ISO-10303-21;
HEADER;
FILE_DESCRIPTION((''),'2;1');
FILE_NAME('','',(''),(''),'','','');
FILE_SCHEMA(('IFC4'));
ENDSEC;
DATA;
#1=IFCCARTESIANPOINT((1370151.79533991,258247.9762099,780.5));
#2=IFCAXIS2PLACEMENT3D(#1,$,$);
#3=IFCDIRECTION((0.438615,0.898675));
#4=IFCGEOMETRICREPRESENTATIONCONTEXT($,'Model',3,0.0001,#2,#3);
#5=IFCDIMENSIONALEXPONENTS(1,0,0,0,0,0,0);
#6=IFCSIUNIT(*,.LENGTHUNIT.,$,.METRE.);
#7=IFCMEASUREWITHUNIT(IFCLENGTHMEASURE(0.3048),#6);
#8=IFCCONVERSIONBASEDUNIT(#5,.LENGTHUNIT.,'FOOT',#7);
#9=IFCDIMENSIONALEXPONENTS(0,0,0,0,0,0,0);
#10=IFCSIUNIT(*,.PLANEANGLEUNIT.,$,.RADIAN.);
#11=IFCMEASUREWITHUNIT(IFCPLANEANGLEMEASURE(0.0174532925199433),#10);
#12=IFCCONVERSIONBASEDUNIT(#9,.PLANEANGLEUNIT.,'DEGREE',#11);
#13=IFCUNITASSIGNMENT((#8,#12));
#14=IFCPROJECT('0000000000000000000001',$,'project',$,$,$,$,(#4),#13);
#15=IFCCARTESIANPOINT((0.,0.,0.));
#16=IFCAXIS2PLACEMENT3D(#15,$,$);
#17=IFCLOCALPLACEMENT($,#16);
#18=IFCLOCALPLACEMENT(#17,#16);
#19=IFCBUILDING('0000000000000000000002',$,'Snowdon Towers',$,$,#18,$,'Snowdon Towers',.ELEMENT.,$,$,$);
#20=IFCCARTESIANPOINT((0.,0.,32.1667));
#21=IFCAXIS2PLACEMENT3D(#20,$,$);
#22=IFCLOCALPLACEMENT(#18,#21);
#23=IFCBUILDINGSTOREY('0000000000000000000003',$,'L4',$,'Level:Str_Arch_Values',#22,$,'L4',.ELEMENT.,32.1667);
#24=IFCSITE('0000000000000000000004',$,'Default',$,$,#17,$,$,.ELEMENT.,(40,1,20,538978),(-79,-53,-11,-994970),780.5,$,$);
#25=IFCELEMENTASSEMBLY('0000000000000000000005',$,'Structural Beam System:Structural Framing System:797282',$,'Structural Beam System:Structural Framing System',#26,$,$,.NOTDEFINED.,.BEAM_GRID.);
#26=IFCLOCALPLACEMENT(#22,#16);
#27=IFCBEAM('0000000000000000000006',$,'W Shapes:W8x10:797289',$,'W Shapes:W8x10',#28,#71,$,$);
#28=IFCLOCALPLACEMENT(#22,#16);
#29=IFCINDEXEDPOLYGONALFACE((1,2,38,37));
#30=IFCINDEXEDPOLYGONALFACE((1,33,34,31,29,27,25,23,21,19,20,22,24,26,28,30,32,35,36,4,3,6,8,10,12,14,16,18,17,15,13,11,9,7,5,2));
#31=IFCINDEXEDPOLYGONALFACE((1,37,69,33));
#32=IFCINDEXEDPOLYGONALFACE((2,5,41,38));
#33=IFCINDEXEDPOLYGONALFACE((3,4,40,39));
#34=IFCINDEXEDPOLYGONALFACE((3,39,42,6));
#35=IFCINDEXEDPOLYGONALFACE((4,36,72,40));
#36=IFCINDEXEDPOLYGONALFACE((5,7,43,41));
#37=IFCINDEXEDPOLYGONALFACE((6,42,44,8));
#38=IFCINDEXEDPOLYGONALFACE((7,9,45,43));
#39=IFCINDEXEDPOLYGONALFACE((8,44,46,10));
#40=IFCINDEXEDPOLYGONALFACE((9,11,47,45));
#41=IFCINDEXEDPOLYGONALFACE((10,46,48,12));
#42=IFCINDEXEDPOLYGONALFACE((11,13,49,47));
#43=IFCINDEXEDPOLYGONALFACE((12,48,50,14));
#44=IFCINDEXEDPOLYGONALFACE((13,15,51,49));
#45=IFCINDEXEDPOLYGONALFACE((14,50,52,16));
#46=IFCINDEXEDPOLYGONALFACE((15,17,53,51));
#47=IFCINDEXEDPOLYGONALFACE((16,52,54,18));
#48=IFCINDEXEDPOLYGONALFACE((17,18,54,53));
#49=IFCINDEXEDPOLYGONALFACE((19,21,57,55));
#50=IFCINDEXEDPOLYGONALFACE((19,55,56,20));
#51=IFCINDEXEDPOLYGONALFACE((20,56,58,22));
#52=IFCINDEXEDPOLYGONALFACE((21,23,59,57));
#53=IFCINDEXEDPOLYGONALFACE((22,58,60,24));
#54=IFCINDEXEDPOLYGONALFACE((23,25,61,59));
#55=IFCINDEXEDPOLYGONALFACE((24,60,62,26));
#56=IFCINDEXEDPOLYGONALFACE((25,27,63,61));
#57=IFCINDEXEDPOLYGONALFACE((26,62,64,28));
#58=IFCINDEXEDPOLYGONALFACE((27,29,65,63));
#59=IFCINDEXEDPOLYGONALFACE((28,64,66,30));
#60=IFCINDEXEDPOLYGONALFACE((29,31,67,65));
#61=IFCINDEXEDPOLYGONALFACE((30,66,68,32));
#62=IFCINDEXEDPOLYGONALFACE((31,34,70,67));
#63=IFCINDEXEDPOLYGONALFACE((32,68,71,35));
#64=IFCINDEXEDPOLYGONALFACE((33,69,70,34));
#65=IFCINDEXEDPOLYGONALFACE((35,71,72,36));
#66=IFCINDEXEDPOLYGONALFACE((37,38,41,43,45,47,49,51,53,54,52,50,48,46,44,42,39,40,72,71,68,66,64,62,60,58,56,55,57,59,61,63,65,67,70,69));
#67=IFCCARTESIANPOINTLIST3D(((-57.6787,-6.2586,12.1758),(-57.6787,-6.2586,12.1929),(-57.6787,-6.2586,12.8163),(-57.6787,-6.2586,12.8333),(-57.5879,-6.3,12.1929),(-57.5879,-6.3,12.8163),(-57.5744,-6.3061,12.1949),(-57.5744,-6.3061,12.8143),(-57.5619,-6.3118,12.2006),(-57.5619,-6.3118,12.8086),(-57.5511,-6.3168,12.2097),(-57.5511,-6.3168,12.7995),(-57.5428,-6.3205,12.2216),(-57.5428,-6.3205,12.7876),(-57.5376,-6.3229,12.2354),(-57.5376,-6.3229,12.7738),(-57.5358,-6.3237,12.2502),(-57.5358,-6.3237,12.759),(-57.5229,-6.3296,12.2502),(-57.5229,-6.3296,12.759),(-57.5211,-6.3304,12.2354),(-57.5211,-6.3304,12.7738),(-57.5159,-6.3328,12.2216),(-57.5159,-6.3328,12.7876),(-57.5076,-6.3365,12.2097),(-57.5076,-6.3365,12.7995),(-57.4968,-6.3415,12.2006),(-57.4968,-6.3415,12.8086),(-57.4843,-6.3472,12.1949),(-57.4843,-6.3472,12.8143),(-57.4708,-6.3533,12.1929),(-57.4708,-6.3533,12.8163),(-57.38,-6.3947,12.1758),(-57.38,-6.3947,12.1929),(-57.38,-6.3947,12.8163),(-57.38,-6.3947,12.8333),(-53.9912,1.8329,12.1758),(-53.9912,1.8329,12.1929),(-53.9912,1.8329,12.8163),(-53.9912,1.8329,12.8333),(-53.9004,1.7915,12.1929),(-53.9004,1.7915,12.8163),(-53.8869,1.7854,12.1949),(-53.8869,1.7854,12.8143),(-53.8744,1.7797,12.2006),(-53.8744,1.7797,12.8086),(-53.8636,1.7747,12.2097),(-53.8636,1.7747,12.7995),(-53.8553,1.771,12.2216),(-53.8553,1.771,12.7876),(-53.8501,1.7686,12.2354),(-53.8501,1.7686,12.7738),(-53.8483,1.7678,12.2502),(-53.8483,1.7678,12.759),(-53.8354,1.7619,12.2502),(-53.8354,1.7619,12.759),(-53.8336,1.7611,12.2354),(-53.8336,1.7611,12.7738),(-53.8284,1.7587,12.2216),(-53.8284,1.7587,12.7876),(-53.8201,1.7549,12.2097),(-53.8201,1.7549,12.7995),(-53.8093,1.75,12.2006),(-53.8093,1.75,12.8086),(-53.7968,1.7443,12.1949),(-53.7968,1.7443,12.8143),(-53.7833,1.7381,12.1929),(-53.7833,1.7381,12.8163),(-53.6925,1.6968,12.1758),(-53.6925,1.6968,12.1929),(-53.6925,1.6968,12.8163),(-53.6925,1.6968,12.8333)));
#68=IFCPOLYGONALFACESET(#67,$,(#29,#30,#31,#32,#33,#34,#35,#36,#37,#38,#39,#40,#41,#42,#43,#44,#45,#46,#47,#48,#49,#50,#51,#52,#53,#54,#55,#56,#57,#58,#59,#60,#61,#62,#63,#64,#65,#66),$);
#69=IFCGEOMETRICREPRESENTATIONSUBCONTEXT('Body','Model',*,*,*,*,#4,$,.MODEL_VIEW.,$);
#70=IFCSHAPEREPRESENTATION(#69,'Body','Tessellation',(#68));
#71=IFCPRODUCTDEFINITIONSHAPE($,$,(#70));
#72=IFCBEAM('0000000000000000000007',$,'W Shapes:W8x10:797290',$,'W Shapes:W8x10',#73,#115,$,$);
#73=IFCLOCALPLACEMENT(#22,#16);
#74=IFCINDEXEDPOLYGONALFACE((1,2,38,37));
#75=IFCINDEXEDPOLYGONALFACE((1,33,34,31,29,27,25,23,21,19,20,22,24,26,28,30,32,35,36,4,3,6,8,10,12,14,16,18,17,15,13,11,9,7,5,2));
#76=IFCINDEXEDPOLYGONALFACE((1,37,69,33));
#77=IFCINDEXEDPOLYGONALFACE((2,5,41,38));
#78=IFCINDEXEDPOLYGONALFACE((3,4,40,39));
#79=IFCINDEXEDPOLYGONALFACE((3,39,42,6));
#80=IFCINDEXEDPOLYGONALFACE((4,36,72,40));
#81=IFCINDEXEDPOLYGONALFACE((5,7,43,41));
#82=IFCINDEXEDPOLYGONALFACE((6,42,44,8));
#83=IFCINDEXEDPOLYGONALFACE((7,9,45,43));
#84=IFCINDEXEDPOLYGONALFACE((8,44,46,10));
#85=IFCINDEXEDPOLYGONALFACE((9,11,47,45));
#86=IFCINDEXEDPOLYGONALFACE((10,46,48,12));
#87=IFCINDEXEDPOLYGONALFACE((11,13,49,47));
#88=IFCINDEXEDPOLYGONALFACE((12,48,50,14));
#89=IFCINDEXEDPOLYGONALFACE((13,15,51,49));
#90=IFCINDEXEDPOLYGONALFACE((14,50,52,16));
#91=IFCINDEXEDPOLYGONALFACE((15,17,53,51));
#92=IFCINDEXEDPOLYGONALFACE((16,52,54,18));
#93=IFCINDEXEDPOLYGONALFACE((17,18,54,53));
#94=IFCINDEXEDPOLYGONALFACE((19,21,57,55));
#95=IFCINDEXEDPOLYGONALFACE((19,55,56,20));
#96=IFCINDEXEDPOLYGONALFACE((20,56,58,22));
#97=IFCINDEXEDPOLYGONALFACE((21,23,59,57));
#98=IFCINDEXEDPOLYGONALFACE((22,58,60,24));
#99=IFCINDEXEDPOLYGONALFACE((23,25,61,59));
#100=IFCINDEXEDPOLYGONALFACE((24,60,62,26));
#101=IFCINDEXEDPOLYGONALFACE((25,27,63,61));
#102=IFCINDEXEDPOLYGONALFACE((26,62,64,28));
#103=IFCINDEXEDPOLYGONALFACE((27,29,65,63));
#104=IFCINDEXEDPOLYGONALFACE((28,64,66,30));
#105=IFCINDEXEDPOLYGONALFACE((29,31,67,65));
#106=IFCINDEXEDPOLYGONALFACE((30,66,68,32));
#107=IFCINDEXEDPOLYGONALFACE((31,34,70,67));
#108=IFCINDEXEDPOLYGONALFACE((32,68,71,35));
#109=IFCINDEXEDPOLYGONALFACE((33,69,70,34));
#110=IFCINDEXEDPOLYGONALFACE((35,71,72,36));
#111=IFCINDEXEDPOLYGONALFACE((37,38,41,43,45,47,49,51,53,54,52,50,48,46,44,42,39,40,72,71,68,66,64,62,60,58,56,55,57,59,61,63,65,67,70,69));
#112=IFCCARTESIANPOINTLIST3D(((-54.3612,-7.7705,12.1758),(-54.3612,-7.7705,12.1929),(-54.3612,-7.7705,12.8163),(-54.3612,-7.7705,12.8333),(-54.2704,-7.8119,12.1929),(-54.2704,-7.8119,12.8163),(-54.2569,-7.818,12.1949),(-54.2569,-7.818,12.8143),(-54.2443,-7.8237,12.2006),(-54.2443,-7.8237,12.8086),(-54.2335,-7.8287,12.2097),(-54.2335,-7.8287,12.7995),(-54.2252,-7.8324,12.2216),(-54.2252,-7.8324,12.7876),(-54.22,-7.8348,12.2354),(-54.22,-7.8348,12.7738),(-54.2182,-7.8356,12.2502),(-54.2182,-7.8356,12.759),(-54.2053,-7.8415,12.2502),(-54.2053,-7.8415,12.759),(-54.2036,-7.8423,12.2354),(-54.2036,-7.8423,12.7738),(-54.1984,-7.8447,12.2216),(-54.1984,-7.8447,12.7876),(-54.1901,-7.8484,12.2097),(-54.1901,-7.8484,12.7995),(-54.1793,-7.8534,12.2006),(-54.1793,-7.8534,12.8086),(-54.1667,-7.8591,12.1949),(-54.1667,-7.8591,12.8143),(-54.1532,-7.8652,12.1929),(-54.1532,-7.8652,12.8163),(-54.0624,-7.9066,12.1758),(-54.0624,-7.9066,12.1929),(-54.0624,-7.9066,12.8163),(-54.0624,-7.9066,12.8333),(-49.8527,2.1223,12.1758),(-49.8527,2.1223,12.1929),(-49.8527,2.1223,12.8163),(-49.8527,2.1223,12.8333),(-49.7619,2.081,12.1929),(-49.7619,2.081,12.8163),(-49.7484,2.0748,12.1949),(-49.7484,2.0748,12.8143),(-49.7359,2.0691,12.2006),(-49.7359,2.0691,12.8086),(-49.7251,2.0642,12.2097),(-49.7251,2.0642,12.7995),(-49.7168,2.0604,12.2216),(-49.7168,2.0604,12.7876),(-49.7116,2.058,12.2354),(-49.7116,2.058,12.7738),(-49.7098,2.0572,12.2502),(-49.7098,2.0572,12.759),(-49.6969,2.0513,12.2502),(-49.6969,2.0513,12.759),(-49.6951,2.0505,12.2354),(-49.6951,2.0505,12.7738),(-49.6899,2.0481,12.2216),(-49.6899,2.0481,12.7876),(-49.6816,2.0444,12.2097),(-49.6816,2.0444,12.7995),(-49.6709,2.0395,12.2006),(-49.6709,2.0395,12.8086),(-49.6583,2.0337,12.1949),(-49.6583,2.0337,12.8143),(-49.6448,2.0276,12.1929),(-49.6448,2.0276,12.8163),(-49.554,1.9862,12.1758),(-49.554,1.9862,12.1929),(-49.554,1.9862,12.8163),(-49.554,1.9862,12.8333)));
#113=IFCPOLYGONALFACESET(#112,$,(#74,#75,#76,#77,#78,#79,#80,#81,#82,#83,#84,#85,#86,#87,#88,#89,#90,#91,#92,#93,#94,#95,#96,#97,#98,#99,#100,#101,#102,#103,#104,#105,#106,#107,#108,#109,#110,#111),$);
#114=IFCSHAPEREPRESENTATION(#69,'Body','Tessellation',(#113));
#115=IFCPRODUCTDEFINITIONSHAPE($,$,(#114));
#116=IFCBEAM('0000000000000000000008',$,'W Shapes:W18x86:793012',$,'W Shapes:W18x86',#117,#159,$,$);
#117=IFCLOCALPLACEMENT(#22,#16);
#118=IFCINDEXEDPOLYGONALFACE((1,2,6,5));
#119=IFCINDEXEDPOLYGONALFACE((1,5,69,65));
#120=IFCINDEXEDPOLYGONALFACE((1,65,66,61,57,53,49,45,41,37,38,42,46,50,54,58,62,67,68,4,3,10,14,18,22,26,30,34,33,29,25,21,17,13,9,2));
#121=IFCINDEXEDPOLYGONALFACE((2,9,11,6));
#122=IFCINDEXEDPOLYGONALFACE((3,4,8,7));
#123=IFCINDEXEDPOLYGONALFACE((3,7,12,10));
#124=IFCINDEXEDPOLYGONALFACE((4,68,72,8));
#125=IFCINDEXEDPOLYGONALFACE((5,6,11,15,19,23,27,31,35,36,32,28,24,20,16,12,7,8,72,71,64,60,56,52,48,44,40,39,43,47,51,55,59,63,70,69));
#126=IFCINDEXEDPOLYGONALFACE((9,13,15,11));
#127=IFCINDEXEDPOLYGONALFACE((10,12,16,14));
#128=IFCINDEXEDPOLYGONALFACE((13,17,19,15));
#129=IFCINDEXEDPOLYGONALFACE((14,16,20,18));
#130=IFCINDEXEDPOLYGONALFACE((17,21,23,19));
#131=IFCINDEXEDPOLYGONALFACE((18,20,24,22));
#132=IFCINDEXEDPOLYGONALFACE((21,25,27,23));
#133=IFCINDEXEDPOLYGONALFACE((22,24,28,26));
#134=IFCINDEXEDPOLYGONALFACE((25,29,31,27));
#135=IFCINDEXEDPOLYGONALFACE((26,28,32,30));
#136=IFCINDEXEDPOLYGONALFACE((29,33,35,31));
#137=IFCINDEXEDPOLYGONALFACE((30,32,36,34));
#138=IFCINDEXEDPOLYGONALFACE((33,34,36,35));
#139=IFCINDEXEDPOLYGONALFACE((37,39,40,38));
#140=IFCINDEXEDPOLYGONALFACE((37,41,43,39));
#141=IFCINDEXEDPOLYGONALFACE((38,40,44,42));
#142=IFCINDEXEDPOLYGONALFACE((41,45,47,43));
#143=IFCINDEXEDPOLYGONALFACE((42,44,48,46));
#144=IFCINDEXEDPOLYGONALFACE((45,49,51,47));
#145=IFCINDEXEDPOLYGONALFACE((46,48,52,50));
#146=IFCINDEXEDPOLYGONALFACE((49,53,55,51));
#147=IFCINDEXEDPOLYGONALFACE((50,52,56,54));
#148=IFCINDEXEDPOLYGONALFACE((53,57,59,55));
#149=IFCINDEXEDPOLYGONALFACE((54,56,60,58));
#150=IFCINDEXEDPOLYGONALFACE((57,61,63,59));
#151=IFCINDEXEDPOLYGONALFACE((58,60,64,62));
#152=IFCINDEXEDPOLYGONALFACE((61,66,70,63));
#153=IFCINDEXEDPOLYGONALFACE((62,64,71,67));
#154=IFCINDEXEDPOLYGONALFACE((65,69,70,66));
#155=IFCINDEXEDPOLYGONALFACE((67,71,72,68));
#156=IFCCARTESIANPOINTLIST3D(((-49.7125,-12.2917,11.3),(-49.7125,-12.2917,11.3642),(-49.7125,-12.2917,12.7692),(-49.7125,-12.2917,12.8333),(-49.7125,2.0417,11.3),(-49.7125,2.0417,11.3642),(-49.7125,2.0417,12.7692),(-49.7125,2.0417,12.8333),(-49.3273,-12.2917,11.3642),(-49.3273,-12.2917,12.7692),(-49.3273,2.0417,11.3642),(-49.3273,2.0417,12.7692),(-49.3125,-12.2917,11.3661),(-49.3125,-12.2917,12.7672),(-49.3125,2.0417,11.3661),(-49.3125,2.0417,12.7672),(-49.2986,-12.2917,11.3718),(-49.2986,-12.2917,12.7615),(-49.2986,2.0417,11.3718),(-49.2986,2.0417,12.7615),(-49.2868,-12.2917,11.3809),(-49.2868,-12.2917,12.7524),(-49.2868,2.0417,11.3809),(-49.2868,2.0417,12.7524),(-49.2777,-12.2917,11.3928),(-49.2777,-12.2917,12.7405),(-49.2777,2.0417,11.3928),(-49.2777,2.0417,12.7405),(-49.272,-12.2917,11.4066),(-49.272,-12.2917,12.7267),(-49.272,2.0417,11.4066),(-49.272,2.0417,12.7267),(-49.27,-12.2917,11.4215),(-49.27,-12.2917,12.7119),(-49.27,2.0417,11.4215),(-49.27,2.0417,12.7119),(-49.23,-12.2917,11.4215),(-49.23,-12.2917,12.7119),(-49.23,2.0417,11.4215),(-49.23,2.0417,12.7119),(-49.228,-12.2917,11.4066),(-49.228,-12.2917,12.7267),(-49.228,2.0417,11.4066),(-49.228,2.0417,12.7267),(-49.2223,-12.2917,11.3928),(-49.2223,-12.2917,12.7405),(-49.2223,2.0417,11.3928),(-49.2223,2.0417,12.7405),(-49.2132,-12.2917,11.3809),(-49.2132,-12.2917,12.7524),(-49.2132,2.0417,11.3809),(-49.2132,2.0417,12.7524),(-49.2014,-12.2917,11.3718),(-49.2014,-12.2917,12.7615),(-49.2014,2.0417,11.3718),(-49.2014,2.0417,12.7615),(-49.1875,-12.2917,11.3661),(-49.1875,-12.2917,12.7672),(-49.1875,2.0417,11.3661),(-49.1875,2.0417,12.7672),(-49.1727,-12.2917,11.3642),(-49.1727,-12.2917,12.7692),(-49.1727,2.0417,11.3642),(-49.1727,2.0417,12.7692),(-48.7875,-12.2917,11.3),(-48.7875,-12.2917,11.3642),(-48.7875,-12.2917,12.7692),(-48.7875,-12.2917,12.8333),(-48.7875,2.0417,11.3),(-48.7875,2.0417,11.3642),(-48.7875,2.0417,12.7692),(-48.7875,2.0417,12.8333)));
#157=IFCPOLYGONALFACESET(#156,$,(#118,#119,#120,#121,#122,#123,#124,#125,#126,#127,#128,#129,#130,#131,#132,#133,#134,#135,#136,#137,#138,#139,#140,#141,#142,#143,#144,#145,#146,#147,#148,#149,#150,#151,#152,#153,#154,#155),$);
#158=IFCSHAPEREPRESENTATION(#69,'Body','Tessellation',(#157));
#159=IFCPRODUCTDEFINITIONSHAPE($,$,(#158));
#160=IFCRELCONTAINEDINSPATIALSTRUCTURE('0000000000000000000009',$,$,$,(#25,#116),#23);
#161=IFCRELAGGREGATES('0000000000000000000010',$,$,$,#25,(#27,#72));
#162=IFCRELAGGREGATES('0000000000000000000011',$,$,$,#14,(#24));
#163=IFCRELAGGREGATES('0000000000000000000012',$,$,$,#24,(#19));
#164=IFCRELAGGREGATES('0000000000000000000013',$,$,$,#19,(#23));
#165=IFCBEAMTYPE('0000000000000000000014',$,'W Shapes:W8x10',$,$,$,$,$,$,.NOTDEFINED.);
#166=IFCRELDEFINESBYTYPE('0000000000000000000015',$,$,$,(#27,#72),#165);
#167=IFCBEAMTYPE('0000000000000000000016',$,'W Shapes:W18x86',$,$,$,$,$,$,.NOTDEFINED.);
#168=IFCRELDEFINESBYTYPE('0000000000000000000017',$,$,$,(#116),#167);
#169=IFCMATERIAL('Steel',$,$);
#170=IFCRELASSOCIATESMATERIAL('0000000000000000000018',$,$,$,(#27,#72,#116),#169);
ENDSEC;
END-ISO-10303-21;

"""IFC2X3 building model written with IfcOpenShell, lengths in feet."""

from ifc_helpers import new_model, entity, si_unit, converted_unit, direction, frame, frame_2d, origin, place, context, subcontext, project, spatial, i_section, extrude, material, type_object, element, aggregate, save


model = new_model("IFC2X3")

# Units and contexts
model_context = context("Model", 3, precision=0.0001, world=frame((1370151.79533991, 258247.9762099, 780.5)), true_north=direction((0.438615, 0.898675)))
body_context = subcontext(model_context, "Body", "Model", "MODEL_VIEW")
ifc_project = project(units=[converted_unit("LENGTHUNIT", "FOOT", entity("IfcLengthMeasure", 0.3048), si_unit("LENGTHUNIT", "METRE"), dimensions=[1, 0, 0, 0, 0, 0, 0]), converted_unit("PLANEANGLEUNIT", "DEGREE", entity("IfcPlaneAngleMeasure", 0.0174532925199433), si_unit("PLANEANGLEUNIT", "RADIAN"), dimensions=[0, 0, 0, 0, 0, 0, 0])], contexts=[model_context])

# Site, building, storey
site_placement = place(None, origin())
site = spatial("IfcSite", under=ifc_project, at=site_placement, Name="Default", CompositionType="ELEMENT", RefLatitude=(40, 1, 20, 538978), RefLongitude=(-79, -53, -11, -994970), RefElevation=780.5)
building_placement = place(site_placement, origin())
building = spatial("IfcBuilding", under=site, at=building_placement, Name="Snowdon Towers", LongName="Snowdon Towers", CompositionType="ELEMENT")
storey_placement = place(building_placement, frame((0.0, 0.0, 32.1667)))
storey = spatial("IfcBuildingStorey", under=building, at=storey_placement, Name="L4", ObjectType="Level:Str_Arch_Values", LongName="L4", CompositionType="ELEMENT", Elevation=32.1667)

# Shared definitions
ifc_material_1 = material(Name="Steel")

# Element assembly, beams
assembly_placement = place(storey_placement, origin())
assembly = element("IfcElementAssembly", 1, at=assembly_placement, inside=storey, Name="Structural Beam System:Structural Framing System:797282", ObjectType="Structural Beam System:Structural Framing System", AssemblyPlace="NOTDEFINED", PredefinedType="BEAM_GRID")
beam_type_1 = type_object("IfcBeamType", Name="W Shapes:W8x10", PredefinedType="NOTDEFINED")
beam_1_placement = place(assembly_placement, frame((-57.6588, -6.6106, 12.8333), z_axis=(0.0, 0.0, 1.0), x_axis=(0.414693, 0.909961, 0.0)))
beam_1 = element("IfcBeam", 2, at=beam_1_placement, type_object=beam_type_1, material=ifc_material_1, Name="W Shapes:W8x10:797289", ObjectType="W Shapes:W8x10", context=body_context, shape_type="SweptSolid", body=[
    extrude(i_section(OverallWidth=0.3283, OverallDepth=0.6575, WebThickness=0.0142, FlangeThickness=0.0171, FilletRadius=0.0573, at=frame_2d((0.0, 0.0), x_axis=(0.0, 1.0))), frame((0.3121, 0.0, -0.3288), z_axis=(1.0, 0.0, 0.0), x_axis=(0.0, 0.0, -1.0)), (0.0, 0.0, 1.0), 8.8921),
])
beam_2_placement = place(assembly_placement, frame((-54.3412, -8.1225, 12.8333), z_axis=(0.0, 0.0, 1.0), x_axis=(0.414693, 0.909961, 0.0)))
beam_2 = element("IfcBeam", 3, at=beam_2_placement, type_object=beam_type_1, material=ifc_material_1, Name="W Shapes:W8x10:797290", ObjectType="W Shapes:W8x10", context=body_context, shape_type="SweptSolid", body=[
    extrude(i_section(OverallWidth=0.3283, OverallDepth=0.6575, WebThickness=0.0142, FlangeThickness=0.0171, FilletRadius=0.0573, at=frame_2d((0.0, 0.0), x_axis=(0.0, 1.0))), frame((0.3121, 0.0, -0.3288), z_axis=(1.0, 0.0, 0.0), x_axis=(0.0, 0.0, -1.0)), (0.0, 0.0, 1.0), 10.8717),
])
aggregate(assembly, [beam_1, beam_2])

# Beam
beam_type_2 = type_object("IfcBeamType", Name="W Shapes:W18x86", PredefinedType="NOTDEFINED")
beam_3_placement = place(storey_placement, frame((-49.25, 2.5, 12.8333), z_axis=(0.0, 0.0, 1.0), x_axis=(0.0, -1.0, 0.0)))
element("IfcBeam", 4, at=beam_3_placement, inside=storey, type_object=beam_type_2, material=ifc_material_1, Name="W Shapes:W18x86:793012", ObjectType="W Shapes:W18x86", context=body_context, shape_type="SweptSolid", body=[
    extrude(i_section(OverallWidth=0.925, OverallDepth=1.5333, WebThickness=0.04, FlangeThickness=0.0642, FilletRadius=0.0573, at=frame_2d((0.0, 0.0), x_axis=(0.0, 1.0))), frame((0.4583, 0.0, -0.7667), z_axis=(1.0, 0.0, 0.0), x_axis=(0.0, 0.0, -1.0)), (0.0, 0.0, 1.0), 14.3333),
])

save(model, "model.ifc")
